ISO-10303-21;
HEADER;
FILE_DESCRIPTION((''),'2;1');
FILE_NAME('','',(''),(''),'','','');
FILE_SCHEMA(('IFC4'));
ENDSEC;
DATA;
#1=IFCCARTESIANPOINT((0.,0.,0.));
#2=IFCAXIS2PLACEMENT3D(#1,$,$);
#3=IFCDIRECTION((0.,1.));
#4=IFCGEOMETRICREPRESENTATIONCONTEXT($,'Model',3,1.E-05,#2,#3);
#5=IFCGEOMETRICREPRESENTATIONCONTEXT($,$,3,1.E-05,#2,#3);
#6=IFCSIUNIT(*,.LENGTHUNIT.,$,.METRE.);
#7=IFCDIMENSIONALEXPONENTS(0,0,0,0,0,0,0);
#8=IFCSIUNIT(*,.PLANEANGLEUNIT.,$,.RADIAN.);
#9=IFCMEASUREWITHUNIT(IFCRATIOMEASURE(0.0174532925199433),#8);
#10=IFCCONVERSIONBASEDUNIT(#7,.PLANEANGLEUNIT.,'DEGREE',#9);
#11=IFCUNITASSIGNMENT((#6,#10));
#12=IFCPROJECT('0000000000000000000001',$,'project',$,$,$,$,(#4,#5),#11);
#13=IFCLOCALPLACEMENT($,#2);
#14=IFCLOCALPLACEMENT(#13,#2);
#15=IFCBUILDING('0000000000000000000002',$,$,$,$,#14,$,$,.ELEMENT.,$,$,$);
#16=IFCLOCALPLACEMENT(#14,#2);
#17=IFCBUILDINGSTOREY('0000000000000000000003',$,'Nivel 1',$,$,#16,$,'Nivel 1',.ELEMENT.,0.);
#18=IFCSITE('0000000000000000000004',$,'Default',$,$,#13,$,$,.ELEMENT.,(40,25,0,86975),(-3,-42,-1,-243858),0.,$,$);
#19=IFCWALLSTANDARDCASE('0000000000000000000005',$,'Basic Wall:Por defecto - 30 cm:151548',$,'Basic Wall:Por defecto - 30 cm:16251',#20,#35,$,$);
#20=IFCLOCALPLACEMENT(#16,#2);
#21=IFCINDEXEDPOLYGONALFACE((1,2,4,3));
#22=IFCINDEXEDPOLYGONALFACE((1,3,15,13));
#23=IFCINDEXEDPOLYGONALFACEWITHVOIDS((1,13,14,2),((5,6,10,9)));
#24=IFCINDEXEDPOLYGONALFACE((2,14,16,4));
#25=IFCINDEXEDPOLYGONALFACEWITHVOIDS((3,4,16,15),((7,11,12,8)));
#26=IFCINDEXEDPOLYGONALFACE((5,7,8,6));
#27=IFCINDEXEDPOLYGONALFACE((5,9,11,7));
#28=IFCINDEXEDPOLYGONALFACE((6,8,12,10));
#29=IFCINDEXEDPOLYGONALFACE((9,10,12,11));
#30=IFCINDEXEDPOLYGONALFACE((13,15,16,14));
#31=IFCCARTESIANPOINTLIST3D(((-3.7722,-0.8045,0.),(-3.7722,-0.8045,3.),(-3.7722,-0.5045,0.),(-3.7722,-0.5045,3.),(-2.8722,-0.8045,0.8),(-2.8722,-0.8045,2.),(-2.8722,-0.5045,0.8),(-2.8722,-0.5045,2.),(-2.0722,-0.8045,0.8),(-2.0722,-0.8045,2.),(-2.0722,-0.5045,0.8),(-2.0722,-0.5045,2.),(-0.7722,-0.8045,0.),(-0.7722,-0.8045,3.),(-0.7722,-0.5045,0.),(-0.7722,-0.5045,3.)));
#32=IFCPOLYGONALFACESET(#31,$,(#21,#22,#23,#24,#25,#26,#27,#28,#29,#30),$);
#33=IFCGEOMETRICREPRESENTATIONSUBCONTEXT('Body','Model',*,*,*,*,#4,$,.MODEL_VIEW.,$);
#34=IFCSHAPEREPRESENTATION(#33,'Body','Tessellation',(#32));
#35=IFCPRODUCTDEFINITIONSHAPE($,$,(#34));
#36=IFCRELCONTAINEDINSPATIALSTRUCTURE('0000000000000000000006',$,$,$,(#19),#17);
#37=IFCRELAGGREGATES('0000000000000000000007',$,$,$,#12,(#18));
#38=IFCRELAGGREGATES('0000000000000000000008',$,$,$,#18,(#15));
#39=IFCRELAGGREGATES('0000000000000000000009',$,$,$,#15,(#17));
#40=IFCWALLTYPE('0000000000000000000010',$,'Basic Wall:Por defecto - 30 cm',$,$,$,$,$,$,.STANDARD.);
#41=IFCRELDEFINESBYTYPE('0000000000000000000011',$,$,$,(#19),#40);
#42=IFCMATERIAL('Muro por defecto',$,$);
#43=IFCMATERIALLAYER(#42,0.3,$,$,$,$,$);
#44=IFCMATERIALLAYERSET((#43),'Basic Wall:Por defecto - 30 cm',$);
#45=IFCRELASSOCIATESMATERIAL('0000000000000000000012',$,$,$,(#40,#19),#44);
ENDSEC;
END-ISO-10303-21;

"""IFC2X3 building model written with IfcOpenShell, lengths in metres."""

from ifc_helpers import new_model, entity, si_unit, converted_unit, direction, frame, frame_2d, origin, place, context, subcontext, project, spatial, rectangle, extrude, material, layer, layer_set, layer_usage, type_object, element, save


model = new_model("IFC2X3")

# Units and contexts
model_context = context("Model", 3, precision=1e-05, world=origin(), true_north=direction((0.0, 1.0)))
context_of_model = context(None, 3, precision=1e-05, world=origin(), true_north=direction((0.0, 1.0)))
body_context = subcontext(model_context, "Body", "Model", "MODEL_VIEW")
ifc_project = project(units=[si_unit("LENGTHUNIT", "METRE"), converted_unit("PLANEANGLEUNIT", "DEGREE", entity("IfcRatioMeasure", 0.0174532925199433), si_unit("PLANEANGLEUNIT", "RADIAN"), dimensions=[0, 0, 0, 0, 0, 0, 0])], contexts=[model_context, context_of_model])

# Site, building, storey
site_placement = place(None, origin())
site = spatial("IfcSite", under=ifc_project, at=site_placement, Name="Default", CompositionType="ELEMENT", RefLatitude=(40, 25, 0, 86975), RefLongitude=(-3, -42, -1, -243858), RefElevation=0.0)
building_placement = place(site_placement, origin())
building = spatial("IfcBuilding", under=site, at=building_placement, CompositionType="ELEMENT")
storey_placement = place(building_placement, origin())
storey = spatial("IfcBuildingStorey", under=building, at=storey_placement, Name="Nivel 1", LongName="Nivel 1", CompositionType="ELEMENT", Elevation=0.0)

# Wall, opening
ifc_material = material(Name="Muro por defecto")
ifc_layer = layer(ifc_material, 0.3)
ifc_layer_set = layer_set([ifc_layer], Name="Basic Wall:Por defecto - 30 cm")
ifc_layer_usage = layer_usage(ifc_layer_set, "AXIS2", "NEGATIVE", 0.15)
wall_type = type_object("IfcWallType", Name="Basic Wall:Por defecto - 30 cm", PredefinedType="STANDARD", material=ifc_layer_set)
wall_placement = place(storey_placement, frame((-3.7722, -0.6545, 0.0)))
wall = element("IfcWallStandardCase", 1, at=wall_placement, inside=storey, type_object=wall_type, material=ifc_layer_usage, Name="Basic Wall:Por defecto - 30 cm:151548", ObjectType="Basic Wall:Por defecto - 30 cm:16251", context=body_context, shape_type="SweptSolid", body=[
    extrude(rectangle(XDim=3.0, YDim=0.3, at=frame_2d((1.5, 0.0), x_axis=(-1.0, 0.0))), origin(), (0.0, 0.0, 1.0), 3.0),
])
opening_placement = place(wall_placement, frame((0.9, -0.15, 0.8)))
element("IfcOpeningElement", 2, at=opening_placement, cuts=wall, ObjectType="Opening", context=body_context, shape_type="SweptSolid", body=[
    extrude(rectangle(XDim=1.2, YDim=0.8, at=frame_2d((0.6, 0.4), x_axis=(1.0, 0.0))), frame((0.0, 0.0, 0.0), z_axis=(0.0, 1.0, 0.0), x_axis=(0.0, 0.0, 1.0)), (0.0, 0.0, 1.0), 0.3),
])

save(model, "model.ifc")
